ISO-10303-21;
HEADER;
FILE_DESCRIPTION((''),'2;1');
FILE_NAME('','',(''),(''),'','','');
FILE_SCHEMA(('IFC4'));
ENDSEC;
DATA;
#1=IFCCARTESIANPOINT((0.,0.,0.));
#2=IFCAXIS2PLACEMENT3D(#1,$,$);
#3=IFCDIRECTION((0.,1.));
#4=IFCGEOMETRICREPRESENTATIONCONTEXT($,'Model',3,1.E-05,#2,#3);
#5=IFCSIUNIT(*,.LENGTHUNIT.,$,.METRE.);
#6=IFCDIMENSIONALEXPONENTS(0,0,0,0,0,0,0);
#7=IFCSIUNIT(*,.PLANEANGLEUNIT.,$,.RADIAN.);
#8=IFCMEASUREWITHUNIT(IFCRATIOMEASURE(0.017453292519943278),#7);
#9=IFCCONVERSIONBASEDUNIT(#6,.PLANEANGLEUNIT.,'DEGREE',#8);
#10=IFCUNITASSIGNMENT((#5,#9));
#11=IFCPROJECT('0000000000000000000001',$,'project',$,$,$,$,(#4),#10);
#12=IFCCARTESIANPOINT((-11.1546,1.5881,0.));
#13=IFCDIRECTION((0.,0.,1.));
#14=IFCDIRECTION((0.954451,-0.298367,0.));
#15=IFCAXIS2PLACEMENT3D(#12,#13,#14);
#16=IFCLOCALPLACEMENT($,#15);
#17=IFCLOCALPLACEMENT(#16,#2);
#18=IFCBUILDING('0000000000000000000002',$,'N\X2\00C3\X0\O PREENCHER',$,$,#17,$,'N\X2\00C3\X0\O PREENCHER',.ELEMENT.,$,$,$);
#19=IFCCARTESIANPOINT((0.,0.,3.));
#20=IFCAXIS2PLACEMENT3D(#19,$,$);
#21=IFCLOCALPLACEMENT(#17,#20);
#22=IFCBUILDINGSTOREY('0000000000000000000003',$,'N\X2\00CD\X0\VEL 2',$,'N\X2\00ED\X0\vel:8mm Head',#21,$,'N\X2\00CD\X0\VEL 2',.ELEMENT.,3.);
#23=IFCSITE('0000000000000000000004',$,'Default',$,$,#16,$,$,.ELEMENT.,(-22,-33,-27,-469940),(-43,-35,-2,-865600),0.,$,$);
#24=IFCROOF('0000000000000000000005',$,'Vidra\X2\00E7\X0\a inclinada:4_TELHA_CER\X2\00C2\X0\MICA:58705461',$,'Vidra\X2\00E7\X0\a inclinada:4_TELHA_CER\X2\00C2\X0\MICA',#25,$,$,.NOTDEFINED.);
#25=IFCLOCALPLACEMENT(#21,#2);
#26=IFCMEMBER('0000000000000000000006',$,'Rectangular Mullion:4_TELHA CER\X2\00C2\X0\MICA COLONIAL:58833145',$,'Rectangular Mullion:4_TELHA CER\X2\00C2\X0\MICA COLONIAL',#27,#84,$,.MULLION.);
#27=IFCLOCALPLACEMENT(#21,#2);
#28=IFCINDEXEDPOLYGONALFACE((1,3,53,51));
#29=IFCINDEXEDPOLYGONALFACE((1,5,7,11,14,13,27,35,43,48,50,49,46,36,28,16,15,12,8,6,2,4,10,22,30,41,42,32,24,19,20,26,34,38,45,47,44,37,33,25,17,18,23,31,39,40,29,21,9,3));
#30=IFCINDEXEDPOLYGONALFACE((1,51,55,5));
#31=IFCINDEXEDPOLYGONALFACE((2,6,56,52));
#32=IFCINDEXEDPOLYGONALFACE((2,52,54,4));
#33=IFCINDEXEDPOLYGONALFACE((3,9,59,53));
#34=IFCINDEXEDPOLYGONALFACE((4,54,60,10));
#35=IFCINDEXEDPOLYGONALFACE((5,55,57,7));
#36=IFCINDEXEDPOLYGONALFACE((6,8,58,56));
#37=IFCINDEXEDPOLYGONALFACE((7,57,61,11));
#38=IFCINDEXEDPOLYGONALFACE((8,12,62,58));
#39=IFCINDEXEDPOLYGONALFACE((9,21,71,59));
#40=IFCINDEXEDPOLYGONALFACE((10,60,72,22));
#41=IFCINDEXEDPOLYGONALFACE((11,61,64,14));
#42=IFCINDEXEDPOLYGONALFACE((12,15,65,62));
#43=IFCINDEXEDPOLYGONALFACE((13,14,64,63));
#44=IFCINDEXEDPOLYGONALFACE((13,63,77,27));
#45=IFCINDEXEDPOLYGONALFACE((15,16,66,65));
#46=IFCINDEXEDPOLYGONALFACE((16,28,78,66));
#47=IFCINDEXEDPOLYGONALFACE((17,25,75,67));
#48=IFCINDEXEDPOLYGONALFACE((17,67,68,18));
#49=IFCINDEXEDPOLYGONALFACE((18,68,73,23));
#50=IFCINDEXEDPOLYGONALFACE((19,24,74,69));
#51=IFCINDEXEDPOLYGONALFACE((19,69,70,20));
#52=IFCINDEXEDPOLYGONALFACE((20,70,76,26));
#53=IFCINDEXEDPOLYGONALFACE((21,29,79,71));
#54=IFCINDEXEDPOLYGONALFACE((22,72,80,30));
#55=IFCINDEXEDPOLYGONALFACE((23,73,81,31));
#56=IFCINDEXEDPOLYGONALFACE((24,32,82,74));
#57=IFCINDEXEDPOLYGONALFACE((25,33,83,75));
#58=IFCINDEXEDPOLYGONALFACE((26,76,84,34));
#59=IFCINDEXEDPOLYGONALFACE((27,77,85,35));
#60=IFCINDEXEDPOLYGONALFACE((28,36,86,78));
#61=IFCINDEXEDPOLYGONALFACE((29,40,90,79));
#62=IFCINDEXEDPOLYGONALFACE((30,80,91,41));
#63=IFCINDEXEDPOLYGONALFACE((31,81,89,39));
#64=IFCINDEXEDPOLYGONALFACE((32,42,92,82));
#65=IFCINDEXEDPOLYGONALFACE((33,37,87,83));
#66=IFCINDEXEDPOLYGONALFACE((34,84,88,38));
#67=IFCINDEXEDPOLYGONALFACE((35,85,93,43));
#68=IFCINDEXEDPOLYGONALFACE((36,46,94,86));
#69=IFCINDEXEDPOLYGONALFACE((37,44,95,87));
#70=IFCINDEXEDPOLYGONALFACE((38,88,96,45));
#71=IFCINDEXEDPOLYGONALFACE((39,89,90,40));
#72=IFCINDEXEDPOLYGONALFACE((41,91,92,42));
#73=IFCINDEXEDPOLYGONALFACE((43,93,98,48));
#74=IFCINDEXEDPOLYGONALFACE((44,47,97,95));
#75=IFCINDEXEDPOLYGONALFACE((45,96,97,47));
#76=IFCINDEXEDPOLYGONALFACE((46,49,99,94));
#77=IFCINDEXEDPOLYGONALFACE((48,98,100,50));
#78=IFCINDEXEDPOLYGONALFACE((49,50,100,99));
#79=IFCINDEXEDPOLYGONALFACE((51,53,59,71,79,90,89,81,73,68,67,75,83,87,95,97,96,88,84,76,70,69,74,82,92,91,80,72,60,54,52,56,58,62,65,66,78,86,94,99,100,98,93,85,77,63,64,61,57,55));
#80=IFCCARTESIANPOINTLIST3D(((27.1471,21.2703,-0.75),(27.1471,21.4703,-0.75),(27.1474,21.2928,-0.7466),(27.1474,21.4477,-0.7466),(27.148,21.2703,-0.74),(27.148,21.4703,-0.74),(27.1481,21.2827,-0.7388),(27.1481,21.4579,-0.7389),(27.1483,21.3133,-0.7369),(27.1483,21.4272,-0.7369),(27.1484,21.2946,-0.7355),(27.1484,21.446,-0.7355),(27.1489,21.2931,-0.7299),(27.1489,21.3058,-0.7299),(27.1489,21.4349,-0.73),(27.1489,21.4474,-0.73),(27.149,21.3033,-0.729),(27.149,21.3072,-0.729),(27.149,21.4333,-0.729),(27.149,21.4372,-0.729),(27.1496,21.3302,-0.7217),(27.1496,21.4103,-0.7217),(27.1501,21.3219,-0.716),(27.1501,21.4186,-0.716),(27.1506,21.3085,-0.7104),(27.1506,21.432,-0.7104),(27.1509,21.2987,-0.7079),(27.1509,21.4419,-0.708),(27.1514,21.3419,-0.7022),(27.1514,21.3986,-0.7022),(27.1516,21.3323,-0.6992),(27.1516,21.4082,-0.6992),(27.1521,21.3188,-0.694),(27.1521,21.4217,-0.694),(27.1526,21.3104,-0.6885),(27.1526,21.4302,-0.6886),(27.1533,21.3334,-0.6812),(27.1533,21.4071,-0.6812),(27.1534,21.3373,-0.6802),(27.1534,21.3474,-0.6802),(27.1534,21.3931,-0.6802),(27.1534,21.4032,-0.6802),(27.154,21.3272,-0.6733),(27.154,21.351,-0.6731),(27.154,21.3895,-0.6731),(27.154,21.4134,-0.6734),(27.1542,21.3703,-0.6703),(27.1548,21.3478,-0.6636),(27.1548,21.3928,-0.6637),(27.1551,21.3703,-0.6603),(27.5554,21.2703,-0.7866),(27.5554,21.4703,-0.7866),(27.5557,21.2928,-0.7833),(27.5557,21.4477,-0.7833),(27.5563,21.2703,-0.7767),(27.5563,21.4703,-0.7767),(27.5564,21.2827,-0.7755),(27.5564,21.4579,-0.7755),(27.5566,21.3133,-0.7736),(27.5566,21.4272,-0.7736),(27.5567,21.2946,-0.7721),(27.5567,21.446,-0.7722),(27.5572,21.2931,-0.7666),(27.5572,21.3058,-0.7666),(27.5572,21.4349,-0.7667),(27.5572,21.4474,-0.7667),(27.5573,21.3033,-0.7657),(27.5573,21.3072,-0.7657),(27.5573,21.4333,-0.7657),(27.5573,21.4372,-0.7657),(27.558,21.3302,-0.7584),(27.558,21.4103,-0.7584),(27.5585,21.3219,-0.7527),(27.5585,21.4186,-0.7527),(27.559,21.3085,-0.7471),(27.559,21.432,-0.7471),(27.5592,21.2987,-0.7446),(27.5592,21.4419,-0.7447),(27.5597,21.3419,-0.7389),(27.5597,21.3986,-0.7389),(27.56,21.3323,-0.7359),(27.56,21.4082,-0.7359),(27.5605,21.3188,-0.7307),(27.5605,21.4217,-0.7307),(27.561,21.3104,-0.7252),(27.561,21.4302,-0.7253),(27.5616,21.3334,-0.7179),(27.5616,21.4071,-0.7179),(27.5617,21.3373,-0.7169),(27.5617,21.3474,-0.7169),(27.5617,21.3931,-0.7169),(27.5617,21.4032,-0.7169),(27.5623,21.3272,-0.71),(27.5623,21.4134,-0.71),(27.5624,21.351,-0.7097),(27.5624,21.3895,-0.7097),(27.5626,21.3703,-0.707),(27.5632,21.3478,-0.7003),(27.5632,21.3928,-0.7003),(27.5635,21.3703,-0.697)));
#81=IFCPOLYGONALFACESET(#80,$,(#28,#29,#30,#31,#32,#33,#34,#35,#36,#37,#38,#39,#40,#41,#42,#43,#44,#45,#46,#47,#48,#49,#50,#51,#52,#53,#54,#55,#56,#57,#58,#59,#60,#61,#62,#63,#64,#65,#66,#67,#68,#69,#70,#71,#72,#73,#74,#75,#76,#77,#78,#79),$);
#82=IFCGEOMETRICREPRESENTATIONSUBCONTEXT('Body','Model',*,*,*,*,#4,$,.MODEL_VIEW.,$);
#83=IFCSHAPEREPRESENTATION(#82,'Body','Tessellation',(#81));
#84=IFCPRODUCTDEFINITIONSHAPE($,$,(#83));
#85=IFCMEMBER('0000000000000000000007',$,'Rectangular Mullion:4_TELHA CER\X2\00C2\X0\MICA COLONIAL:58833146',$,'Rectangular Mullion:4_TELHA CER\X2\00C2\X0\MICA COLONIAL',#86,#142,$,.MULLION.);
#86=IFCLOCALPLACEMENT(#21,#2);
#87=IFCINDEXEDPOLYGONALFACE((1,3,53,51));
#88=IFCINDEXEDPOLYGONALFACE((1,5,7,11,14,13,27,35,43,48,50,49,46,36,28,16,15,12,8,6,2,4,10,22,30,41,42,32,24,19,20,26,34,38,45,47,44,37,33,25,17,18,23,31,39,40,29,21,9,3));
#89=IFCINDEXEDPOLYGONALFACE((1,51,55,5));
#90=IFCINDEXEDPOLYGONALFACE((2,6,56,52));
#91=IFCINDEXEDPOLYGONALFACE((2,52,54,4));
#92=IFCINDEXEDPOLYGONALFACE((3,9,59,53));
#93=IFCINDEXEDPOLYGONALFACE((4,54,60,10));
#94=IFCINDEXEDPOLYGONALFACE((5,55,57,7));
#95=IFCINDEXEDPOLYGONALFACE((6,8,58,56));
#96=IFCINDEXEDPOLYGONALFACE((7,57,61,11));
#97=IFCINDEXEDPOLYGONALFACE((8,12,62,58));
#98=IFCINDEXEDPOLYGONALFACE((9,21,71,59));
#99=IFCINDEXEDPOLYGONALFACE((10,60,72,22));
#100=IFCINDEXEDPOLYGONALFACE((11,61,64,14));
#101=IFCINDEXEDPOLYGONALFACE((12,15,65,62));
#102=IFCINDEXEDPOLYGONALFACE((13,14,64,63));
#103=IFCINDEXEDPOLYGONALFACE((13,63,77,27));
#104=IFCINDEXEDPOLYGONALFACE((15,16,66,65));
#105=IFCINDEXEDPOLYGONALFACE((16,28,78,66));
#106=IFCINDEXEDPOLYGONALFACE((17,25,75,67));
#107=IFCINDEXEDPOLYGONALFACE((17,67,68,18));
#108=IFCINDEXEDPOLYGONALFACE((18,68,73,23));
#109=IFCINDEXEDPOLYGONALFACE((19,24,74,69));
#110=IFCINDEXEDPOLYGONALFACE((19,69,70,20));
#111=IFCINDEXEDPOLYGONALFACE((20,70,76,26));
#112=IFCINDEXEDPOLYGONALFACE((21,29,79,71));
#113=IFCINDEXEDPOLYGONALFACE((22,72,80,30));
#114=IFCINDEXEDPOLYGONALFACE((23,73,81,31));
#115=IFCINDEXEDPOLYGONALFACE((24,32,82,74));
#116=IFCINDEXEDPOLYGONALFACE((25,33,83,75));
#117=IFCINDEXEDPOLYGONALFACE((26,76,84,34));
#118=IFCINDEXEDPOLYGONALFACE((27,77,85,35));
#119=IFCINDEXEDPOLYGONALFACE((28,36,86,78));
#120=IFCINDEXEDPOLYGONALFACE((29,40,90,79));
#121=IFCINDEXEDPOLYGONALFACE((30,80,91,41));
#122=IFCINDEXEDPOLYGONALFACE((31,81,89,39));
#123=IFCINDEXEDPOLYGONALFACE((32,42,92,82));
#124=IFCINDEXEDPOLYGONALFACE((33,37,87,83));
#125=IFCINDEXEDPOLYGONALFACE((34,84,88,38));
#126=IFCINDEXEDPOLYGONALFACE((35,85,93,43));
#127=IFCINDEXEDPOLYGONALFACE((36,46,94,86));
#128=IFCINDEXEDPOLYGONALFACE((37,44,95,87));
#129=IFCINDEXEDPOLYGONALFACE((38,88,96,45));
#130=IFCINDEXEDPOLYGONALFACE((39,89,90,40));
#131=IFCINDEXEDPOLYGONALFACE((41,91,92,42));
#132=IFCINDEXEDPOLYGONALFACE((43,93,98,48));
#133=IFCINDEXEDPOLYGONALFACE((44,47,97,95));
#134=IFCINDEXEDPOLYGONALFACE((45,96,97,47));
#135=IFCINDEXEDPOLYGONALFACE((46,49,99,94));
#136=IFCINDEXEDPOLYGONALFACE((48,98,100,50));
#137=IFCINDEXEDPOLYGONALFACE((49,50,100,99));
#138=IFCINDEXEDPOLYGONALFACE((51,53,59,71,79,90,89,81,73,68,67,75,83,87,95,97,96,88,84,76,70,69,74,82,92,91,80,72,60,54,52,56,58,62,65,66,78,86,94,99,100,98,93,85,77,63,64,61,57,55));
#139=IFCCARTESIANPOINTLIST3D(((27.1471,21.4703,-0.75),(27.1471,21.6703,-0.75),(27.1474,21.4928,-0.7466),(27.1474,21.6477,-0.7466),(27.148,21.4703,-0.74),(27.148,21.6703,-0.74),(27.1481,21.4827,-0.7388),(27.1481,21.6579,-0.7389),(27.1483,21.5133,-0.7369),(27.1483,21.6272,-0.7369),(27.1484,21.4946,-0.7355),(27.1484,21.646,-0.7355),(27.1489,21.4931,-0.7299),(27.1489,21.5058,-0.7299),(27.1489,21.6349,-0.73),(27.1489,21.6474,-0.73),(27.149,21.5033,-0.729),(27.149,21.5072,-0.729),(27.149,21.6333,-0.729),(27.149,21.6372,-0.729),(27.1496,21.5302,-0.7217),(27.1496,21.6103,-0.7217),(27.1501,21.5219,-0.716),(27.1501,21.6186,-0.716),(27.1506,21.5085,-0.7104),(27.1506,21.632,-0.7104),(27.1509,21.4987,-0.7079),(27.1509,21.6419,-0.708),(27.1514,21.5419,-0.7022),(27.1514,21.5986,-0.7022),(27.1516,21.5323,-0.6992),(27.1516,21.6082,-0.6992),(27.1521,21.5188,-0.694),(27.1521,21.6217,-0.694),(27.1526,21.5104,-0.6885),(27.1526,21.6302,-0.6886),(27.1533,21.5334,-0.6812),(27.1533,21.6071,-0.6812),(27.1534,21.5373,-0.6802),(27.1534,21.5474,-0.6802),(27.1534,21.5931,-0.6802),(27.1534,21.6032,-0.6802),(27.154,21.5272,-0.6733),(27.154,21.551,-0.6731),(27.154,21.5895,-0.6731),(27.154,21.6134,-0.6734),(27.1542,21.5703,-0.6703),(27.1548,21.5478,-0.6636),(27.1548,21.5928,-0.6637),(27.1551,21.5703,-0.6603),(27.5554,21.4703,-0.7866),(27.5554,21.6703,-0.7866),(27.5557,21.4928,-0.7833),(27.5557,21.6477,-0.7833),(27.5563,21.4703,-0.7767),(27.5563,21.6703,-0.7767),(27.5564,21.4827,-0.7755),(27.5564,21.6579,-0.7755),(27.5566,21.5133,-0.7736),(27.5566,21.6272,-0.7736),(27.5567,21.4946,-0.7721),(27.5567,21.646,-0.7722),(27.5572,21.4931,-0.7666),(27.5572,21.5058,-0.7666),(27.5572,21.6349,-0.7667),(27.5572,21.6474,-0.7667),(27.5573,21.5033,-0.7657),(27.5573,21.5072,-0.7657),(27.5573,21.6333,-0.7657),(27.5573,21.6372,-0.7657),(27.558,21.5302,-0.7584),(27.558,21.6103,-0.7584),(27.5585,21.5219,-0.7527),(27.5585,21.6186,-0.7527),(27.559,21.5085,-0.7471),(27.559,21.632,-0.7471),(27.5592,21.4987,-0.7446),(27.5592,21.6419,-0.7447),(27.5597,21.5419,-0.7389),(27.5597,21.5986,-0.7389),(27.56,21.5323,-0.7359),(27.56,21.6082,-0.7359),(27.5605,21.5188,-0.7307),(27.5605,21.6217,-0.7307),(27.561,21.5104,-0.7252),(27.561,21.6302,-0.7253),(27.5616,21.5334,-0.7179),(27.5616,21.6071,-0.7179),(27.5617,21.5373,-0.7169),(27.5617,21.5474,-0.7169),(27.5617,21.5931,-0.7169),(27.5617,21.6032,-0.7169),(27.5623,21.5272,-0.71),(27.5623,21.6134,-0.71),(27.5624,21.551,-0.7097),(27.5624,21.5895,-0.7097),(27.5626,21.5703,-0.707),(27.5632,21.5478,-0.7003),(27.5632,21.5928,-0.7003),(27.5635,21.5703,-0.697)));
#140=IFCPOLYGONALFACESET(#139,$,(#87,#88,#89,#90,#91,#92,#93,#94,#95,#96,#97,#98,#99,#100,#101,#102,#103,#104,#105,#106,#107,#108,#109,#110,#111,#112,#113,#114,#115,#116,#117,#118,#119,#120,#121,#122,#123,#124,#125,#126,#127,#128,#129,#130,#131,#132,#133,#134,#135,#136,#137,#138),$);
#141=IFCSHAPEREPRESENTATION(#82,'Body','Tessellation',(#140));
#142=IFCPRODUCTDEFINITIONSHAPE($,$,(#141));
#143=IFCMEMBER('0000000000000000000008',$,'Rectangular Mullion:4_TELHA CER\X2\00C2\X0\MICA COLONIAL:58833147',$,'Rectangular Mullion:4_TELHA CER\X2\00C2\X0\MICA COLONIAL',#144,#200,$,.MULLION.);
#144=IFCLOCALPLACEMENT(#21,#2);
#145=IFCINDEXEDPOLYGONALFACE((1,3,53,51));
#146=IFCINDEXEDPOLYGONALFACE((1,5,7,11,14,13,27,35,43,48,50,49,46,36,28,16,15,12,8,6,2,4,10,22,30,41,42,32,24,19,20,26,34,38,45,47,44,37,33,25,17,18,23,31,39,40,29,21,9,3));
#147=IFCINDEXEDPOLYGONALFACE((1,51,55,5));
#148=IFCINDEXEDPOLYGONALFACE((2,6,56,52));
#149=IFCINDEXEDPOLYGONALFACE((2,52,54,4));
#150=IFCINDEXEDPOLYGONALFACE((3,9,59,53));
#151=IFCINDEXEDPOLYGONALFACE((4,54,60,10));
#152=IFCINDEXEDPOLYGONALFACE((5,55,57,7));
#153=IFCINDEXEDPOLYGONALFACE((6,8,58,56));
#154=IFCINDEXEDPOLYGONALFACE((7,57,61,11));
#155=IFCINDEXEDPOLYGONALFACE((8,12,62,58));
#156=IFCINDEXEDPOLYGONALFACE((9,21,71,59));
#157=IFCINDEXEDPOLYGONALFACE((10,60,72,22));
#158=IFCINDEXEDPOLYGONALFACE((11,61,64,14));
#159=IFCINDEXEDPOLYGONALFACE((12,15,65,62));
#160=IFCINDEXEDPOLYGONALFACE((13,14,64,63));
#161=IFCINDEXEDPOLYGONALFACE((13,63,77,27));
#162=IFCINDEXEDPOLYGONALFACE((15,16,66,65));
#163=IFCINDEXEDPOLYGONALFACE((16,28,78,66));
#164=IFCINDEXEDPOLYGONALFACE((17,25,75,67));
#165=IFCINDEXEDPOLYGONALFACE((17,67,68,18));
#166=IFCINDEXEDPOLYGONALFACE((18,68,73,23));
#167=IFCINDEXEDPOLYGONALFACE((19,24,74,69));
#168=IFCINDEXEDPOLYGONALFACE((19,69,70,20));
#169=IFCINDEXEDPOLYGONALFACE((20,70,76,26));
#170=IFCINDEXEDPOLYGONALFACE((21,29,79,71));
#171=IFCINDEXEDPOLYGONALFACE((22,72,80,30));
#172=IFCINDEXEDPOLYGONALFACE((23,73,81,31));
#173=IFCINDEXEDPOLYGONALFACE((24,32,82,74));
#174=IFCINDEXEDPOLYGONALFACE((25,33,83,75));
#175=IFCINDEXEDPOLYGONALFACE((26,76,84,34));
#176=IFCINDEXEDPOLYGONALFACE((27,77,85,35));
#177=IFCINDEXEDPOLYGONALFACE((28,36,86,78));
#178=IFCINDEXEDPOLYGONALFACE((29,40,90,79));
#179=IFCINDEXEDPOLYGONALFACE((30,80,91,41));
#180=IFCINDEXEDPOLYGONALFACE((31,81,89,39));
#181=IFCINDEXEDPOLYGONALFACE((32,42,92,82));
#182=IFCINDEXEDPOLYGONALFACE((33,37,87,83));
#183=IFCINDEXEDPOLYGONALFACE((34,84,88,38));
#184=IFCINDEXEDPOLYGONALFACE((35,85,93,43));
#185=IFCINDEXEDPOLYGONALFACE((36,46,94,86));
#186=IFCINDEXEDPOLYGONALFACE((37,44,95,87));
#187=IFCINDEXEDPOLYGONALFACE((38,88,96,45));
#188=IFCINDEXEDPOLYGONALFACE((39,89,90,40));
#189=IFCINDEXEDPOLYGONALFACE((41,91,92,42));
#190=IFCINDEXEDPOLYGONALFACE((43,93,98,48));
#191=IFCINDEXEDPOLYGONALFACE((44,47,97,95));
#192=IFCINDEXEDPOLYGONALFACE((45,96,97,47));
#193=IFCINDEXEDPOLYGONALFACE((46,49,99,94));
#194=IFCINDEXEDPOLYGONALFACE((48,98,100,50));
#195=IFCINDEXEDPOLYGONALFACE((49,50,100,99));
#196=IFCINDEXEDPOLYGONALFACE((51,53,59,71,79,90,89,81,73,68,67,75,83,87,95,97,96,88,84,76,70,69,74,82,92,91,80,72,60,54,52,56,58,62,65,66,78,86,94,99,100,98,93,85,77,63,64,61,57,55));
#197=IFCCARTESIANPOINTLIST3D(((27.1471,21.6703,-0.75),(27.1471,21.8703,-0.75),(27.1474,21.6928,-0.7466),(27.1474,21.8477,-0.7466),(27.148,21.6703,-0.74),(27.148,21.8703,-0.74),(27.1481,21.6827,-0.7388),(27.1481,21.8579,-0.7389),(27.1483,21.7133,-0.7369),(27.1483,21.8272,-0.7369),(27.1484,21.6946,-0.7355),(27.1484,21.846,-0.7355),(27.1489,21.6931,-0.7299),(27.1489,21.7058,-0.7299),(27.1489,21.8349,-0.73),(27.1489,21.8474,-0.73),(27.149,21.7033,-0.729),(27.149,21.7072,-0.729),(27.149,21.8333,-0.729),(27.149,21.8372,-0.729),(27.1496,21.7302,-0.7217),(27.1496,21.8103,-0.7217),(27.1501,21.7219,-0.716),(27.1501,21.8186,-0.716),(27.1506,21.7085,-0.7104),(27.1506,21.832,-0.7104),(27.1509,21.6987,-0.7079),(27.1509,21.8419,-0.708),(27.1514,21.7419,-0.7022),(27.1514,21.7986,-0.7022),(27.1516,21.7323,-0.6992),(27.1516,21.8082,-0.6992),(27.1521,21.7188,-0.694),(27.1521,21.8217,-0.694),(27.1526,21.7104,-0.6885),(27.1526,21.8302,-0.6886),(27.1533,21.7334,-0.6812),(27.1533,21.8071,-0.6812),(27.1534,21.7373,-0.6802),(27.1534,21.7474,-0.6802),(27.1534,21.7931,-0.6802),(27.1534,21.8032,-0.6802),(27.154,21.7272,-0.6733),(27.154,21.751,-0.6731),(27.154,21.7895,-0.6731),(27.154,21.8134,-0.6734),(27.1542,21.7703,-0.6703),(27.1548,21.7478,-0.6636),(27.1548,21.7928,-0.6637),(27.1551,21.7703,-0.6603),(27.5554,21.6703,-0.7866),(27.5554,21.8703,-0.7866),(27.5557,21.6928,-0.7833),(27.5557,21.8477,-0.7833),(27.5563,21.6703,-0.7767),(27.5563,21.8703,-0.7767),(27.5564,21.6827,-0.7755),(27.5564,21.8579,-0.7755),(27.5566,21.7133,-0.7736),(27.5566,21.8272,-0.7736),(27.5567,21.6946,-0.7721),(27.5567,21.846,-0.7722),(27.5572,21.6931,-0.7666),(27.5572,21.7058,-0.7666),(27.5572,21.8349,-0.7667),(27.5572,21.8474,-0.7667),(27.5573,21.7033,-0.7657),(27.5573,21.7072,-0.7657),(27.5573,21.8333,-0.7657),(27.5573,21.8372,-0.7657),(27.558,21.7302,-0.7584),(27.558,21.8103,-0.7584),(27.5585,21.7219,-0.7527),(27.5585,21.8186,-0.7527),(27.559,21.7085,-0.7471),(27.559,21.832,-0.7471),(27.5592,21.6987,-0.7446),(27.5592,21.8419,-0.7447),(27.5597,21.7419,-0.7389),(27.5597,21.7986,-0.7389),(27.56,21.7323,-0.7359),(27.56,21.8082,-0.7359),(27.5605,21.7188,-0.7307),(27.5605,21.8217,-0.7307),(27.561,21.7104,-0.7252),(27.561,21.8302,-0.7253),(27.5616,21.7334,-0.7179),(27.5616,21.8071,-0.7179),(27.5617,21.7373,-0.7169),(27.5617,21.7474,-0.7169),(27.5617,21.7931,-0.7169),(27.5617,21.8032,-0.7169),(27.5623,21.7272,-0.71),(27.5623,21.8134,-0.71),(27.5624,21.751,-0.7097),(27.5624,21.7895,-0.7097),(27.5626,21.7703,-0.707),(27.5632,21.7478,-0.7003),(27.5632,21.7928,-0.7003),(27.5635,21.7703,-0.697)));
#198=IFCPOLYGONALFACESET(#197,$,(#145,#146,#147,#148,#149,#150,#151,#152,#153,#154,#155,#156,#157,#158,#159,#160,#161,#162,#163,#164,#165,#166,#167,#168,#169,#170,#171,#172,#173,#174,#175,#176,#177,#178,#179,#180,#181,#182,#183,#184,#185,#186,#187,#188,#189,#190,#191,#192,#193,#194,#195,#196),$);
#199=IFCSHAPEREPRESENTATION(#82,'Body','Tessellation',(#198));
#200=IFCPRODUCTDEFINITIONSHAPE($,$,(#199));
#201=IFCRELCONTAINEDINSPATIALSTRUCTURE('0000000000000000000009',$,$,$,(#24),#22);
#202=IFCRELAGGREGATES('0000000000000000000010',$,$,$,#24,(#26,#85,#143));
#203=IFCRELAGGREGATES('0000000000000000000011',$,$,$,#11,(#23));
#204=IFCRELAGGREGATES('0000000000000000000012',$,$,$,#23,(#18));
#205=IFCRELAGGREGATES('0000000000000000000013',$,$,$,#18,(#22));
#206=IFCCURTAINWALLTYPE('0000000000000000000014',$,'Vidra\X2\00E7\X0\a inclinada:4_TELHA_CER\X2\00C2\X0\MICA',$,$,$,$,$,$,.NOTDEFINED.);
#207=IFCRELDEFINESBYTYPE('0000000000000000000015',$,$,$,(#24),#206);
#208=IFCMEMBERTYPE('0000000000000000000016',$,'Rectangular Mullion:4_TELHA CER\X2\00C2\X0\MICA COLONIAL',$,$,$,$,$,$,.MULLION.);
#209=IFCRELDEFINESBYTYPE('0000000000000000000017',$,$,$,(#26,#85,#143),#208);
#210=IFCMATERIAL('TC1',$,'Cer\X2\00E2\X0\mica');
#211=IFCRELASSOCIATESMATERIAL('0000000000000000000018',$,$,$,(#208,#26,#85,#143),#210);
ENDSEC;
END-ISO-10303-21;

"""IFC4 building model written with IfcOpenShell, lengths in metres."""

from ifc_helpers import new_model, entity, si_unit, converted_unit, direction, frame, origin, place, context, subcontext, project, spatial, line, arc, indexed_curve, outline, extrude, source, transform, mapped, material, type_object, type_shapes, element, aggregate, save


model = new_model("IFC4")

# Units and contexts
model_context = context("Model", 3, precision=1e-05, world=origin(), true_north=direction((0.0, 1.0)))
body_context = subcontext(model_context, "Body", "Model", "MODEL_VIEW")
ifc_project = project(units=[si_unit("LENGTHUNIT", "METRE"), converted_unit("PLANEANGLEUNIT", "DEGREE", entity("IfcRatioMeasure", 0.017453292519943278), si_unit("PLANEANGLEUNIT", "RADIAN"), dimensions=[0, 0, 0, 0, 0, 0, 0])], contexts=[model_context])

# Site, building, storey
site_placement = place(None, frame((-11.1546, 1.5881, 0.0), z_axis=(0.0, 0.0, 1.0), x_axis=(0.954451, -0.298367, 0.0)))
site = spatial("IfcSite", under=ifc_project, at=site_placement, Name="Default", CompositionType="ELEMENT", RefLatitude=(-22, -33, -27, -469940), RefLongitude=(-43, -35, -2, -865600), RefElevation=0.0)
building_placement = place(site_placement, origin())
building = spatial("IfcBuilding", under=site, at=building_placement, Name="NÃO PREENCHER", LongName="NÃO PREENCHER", CompositionType="ELEMENT")
storey_placement = place(building_placement, frame((0.0, 0.0, 3.0)))
storey = spatial("IfcBuildingStorey", under=building, at=storey_placement, Name="NÍVEL 2", ObjectType="Nível:8mm Head", LongName="NÍVEL 2", CompositionType="ELEMENT", Elevation=3.0)

# Roof, members
curtain_wall_type = type_object("IfcCurtainWallType", Name="Vidraça inclinada:4_TELHA_CERÂMICA", PredefinedType="NOTDEFINED")
roof_placement = place(storey_placement, frame((0.0, 0.0, -3.0)))
roof = element("IfcRoof", 1, at=roof_placement, inside=storey, type_object=curtain_wall_type, Name="Vidraça inclinada:4_TELHA_CERÂMICA:58705461", ObjectType="Vidraça inclinada:4_TELHA_CERÂMICA", PredefinedType="NOTDEFINED")
ifc_material = material(Name="TC1", Category="Cerâmica")
member_type_1 = type_object("IfcMemberType", Name="Rectangular Mullion:4_TELHA CERÂMICA COLONIAL", PredefinedType="MULLION", material=ifc_material)
shared_shape_1 = source(origin(), body_context, "Body", "SweptSolid", [
    extrude(outline(indexed_curve([(-0.029, -0.1), (-0.019, -0.1), (-0.0164, -0.0815), (-0.0089, -0.0645), (-0.0089, -0.0771), (0.061, 0.0), (-0.009, 0.0771), (-0.009, 0.0646), (-0.0165, 0.0816), (-0.019, 0.1), (-0.029, 0.1), (-0.0089, 0.0479), (0.041, 0.0229), (0.041, 0.0329), (0.0131, 0.0425), (-0.008, 0.0631), (-0.008, 0.067), (0.051, 0.0), (-0.008, -0.067), (-0.008, -0.0631), (0.0131, -0.0425), (0.041, -0.0329), (0.041, -0.0229), (-0.0089, -0.0479)], segments=[line(1, 2), arc(2, 3, 4), line(4, 5), arc(5, 6, 7), line(7, 8), arc(8, 9, 10), line(10, 11), arc(11, 12, 13), line(13, 14), arc(14, 15, 16), line(16, 17), arc(17, 18, 19), line(19, 20), arc(20, 21, 22), line(22, 23), arc(23, 24, 1)], self_intersect=False)), frame((0.0, -0.029, -0.41), z_axis=(0.0, 0.0, 1.0), x_axis=(0.0, -1.0, 0.0)), (0.0, 0.0, 1.0), 0.41),
])
type_shapes(member_type_1, [shared_shape_1])
member_1_placement = place(roof_placement, frame((27.1471, 21.3703, 2.25), z_axis=(-0.99599, 0.0, 0.089469), x_axis=(0.0, 1.0, 0.0)))
member_1 = element("IfcMember", 2, at=member_1_placement, type_object=member_type_1, material=ifc_material, Name="Rectangular Mullion:4_TELHA CERÂMICA COLONIAL:58833145", ObjectType="Rectangular Mullion:4_TELHA CERÂMICA COLONIAL", PredefinedType="MULLION", context=body_context, shape_type="MappedRepresentation", body=[
    mapped(shared_shape_1, transform((0.0, 0.0, 0.0), scale=1.0)),
])
member_2_placement = place(roof_placement, frame((27.1471, 21.5703, 2.25), z_axis=(-0.99599, 0.0, 0.089469), x_axis=(0.0, 1.0, 0.0)))
member_2 = element("IfcMember", 3, at=member_2_placement, type_object=member_type_1, material=ifc_material, Name="Rectangular Mullion:4_TELHA CERÂMICA COLONIAL:58833146", ObjectType="Rectangular Mullion:4_TELHA CERÂMICA COLONIAL", PredefinedType="MULLION", context=body_context, shape_type="MappedRepresentation", body=[
    mapped(shared_shape_1, transform((0.0, 0.0, 0.0), scale=1.0)),
])
member_3_placement = place(roof_placement, frame((27.1471, 21.7703, 2.25), z_axis=(-0.99599, 0.0, 0.089469), x_axis=(0.0, 1.0, 0.0)))
member_3 = element("IfcMember", 4, at=member_3_placement, type_object=member_type_1, material=ifc_material, Name="Rectangular Mullion:4_TELHA CERÂMICA COLONIAL:58833147", ObjectType="Rectangular Mullion:4_TELHA CERÂMICA COLONIAL", PredefinedType="MULLION", context=body_context, shape_type="MappedRepresentation", body=[
    mapped(shared_shape_1, transform((0.0, 0.0, 0.0), scale=1.0)),
])
aggregate(roof, [member_1, member_2, member_3])

save(model, "model.ifc")
